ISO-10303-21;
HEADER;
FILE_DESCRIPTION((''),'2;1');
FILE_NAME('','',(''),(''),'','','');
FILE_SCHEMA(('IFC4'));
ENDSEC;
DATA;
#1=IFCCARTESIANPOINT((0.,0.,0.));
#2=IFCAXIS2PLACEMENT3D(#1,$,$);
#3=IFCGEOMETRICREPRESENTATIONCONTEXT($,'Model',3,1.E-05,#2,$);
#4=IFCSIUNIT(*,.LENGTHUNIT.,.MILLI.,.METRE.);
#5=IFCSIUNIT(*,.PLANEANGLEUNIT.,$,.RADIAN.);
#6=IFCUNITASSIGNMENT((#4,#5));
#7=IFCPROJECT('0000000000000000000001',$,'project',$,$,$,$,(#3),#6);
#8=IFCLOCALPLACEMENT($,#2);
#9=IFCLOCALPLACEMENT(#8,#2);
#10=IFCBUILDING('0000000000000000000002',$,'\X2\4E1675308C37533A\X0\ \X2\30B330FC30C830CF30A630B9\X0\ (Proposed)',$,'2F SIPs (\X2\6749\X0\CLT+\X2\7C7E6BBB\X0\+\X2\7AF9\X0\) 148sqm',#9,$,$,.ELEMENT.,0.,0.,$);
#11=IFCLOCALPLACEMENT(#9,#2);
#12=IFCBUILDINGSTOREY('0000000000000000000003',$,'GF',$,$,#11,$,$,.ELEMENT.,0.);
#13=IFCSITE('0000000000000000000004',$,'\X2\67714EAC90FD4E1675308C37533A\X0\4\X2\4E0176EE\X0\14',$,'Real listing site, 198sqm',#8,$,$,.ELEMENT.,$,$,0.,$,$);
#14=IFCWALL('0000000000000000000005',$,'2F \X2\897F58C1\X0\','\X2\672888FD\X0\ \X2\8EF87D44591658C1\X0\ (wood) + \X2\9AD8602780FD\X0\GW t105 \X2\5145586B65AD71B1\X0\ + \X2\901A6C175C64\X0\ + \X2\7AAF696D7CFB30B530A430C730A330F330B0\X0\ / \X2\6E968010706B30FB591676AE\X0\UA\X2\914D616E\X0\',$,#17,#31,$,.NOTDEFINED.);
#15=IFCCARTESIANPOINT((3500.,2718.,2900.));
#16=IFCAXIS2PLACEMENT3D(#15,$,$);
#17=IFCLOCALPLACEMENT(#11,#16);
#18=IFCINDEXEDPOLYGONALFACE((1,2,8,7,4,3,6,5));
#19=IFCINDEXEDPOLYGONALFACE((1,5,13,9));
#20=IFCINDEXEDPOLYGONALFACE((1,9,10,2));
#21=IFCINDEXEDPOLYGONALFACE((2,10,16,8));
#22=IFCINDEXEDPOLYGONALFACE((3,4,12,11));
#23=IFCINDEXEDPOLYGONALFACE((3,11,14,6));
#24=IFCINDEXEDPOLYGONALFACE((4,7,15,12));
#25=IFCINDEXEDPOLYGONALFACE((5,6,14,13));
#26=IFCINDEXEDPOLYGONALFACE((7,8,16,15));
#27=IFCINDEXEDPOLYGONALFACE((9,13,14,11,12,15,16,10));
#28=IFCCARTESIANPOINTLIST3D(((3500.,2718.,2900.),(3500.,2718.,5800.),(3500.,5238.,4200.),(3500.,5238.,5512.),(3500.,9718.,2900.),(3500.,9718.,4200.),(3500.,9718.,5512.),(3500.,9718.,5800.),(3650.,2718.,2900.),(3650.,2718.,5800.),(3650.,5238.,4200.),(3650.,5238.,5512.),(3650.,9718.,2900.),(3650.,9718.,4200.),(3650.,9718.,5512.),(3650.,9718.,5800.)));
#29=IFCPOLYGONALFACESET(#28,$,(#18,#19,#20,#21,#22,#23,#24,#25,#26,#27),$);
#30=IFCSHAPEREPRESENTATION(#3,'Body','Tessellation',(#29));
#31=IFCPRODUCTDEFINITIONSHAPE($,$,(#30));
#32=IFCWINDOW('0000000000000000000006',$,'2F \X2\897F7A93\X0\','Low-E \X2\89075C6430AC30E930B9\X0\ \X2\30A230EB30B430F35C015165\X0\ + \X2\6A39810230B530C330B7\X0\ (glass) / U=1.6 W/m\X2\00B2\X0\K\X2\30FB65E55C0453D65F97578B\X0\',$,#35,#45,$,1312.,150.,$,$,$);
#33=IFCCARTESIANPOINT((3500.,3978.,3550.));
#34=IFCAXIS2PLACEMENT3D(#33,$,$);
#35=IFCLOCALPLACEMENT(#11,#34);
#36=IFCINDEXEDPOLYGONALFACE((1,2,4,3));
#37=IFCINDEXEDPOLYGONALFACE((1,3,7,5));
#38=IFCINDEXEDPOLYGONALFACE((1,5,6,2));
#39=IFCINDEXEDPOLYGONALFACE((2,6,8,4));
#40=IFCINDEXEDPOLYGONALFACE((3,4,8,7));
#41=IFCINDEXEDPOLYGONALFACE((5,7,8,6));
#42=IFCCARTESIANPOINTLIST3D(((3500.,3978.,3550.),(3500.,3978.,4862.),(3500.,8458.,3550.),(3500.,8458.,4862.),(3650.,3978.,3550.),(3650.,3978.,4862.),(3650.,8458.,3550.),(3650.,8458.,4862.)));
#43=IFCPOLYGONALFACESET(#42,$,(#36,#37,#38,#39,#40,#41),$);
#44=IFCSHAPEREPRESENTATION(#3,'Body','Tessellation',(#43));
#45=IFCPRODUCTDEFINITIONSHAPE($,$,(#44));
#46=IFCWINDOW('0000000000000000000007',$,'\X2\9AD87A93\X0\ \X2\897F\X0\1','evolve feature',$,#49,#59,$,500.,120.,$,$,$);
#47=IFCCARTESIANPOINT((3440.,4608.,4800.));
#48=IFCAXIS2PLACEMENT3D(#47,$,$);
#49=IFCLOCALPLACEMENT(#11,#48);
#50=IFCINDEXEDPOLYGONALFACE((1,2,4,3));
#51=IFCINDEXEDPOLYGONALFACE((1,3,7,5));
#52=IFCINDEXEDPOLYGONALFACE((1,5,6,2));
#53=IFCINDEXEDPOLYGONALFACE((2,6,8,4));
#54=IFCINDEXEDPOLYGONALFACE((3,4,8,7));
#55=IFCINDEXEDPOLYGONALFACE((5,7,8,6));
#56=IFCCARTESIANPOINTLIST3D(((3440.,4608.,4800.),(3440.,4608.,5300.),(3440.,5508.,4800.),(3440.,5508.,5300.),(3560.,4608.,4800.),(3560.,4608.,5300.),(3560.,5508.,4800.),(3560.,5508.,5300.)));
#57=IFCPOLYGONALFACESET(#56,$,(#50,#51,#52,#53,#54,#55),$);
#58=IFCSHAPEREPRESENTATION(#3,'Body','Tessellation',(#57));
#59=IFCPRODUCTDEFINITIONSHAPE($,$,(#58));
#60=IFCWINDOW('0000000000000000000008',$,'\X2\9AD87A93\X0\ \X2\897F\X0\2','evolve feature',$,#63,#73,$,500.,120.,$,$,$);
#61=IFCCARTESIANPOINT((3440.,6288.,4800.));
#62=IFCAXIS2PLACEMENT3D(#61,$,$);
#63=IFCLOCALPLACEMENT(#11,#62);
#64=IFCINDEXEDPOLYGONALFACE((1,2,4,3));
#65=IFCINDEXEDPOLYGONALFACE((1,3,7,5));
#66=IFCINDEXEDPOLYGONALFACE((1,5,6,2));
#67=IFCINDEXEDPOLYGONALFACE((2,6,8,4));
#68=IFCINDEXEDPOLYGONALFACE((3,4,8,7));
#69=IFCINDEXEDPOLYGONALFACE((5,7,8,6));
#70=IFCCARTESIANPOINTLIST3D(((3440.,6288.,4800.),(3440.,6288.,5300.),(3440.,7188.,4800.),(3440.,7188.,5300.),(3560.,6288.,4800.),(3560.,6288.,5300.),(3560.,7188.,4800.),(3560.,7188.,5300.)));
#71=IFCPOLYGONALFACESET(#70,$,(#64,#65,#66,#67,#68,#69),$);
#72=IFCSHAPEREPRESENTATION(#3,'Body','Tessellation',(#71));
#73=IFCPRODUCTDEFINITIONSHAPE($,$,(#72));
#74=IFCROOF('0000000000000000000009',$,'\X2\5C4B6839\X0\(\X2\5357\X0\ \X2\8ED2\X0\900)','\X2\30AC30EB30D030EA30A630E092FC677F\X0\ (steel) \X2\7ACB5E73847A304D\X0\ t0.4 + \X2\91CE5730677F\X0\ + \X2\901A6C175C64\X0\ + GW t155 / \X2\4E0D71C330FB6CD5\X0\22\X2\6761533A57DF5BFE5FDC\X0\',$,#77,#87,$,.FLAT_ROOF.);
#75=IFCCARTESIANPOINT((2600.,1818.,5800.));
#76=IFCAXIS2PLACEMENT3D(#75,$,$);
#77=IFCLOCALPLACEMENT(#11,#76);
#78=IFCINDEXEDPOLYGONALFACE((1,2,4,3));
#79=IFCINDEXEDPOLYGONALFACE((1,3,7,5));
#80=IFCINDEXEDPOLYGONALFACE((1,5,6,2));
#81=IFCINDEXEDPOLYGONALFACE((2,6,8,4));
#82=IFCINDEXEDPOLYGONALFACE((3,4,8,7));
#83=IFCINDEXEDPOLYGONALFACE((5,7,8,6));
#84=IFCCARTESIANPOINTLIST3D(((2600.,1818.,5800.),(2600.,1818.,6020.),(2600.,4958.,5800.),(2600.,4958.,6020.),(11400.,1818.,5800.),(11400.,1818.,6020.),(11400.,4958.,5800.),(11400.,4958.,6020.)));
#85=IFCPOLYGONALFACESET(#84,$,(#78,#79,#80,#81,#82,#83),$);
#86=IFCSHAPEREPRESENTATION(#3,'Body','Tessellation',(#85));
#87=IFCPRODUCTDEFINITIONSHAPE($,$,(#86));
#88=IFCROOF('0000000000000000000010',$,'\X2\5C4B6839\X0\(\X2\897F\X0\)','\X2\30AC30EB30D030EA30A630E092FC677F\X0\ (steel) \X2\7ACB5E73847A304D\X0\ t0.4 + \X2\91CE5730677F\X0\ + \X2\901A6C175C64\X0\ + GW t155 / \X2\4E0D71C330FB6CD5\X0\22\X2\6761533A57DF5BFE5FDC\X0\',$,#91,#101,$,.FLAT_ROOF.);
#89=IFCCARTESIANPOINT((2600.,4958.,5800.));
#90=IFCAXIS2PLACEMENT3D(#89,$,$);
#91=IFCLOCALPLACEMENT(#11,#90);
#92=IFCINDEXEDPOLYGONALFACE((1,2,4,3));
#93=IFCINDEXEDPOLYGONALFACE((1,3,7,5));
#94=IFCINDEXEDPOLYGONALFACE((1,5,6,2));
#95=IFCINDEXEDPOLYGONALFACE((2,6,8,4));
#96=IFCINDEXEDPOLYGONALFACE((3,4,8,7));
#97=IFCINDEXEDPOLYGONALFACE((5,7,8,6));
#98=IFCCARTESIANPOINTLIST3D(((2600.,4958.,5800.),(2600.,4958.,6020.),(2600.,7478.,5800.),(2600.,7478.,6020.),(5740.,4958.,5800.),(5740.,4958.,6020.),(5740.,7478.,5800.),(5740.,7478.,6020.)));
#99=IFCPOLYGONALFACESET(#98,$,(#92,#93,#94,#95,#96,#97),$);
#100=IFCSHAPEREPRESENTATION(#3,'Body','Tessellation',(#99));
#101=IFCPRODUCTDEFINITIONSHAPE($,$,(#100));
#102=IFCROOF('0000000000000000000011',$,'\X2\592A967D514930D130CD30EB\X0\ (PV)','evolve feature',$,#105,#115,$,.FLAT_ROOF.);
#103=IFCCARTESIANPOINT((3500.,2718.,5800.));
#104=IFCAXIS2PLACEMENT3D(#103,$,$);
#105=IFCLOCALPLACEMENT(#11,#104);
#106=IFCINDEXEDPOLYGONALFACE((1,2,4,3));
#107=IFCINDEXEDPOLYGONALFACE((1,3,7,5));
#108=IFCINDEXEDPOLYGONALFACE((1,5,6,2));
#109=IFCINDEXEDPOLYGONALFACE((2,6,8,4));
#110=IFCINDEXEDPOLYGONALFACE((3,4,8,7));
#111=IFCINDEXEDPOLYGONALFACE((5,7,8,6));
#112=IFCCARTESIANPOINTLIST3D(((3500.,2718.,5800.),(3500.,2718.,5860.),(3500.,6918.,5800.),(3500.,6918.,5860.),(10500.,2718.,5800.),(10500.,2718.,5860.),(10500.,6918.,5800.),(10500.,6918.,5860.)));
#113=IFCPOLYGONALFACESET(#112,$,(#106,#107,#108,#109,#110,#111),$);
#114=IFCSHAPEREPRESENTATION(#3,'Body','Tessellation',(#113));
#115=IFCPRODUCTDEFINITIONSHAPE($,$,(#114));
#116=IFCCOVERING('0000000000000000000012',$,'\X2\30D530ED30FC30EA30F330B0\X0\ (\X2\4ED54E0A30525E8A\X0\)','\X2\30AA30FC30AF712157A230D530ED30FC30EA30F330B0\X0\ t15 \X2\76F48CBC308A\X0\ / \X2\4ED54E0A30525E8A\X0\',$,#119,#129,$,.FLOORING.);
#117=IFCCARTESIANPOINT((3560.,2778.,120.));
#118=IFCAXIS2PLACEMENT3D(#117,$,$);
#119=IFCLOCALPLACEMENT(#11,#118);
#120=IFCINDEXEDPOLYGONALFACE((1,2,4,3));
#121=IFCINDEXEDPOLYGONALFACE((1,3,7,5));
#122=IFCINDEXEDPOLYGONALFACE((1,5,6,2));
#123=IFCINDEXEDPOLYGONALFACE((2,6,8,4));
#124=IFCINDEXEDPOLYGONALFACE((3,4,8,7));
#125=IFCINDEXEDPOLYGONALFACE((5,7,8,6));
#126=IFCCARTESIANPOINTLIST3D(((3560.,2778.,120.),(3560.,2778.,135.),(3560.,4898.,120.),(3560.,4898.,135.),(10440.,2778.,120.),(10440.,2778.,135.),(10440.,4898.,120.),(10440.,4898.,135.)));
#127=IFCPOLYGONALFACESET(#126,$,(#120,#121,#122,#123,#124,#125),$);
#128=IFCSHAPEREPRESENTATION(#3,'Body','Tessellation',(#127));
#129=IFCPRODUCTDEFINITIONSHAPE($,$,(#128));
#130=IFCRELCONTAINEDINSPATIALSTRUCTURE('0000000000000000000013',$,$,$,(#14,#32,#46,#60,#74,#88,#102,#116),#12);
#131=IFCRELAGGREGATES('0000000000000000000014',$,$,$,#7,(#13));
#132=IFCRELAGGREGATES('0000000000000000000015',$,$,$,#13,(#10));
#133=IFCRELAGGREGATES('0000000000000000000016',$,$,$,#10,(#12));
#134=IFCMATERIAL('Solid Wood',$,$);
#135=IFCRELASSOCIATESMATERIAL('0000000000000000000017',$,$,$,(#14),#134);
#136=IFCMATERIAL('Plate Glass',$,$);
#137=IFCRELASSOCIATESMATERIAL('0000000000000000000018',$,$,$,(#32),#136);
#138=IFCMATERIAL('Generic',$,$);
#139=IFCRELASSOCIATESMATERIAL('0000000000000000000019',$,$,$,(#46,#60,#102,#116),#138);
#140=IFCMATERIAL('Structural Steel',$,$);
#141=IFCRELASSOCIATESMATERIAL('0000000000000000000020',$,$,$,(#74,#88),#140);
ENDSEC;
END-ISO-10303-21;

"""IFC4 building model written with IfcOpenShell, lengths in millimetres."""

from ifc_helpers import new_model, si_unit, frame, frame_2d, origin, place, context, project, spatial, rectangle, extrude, material, element, fill, save


model = new_model("IFC4")

# Units and contexts
model_context = context("Model", 3, precision=1e-05, world=origin())
ifc_project = project(units=[si_unit("LENGTHUNIT", "METRE", prefix="MILLI"), si_unit("PLANEANGLEUNIT", "RADIAN")], contexts=[model_context])

# Site, building, storey
site_placement = place(None, origin())
site = spatial("IfcSite", under=ifc_project, at=site_placement, Name="東京都世田谷区4丁目14", ObjectType="Real listing site, 198sqm", CompositionType="ELEMENT", RefElevation=0.0)
building_placement = place(site_placement, origin())
building = spatial("IfcBuilding", under=site, at=building_placement, Name="世田谷区 コートハウス (Proposed)", ObjectType="2F SIPs (杉CLT+籾殻+竹) 148sqm", CompositionType="ELEMENT", ElevationOfRefHeight=0.0, ElevationOfTerrain=0.0)
storey_placement = place(building_placement, origin())
storey = spatial("IfcBuildingStorey", under=building, at=storey_placement, Name="GF", CompositionType="ELEMENT", Elevation=0.0)

# Shared definitions
ifc_material_1 = material(Name="Solid Wood")
ifc_material_2 = material(Name="Generic")

# Shared definitions
ifc_material_3 = material(Name="Plate Glass")

# Wall, openings, windows
wall_1_placement = place(storey_placement, frame((3500.0, 2718.0, 2900.0)))
wall_1 = element("IfcWall", 1, at=wall_1_placement, inside=storey, material=ifc_material_1, Name="2F 西壁", Description="木製 軸組外壁 (wood) + 高性能GW t105 充填断熱 + 通気層 + 窯業系サイディング / 準耐火・外皮UA配慮", PredefinedType="NOTDEFINED", context=model_context, shape_type="SweptSolid", body=[
    extrude(rectangle(XDim=150.0, YDim=7000.0, at=frame_2d((75.0, 3500.0))), frame((3500.0, 2718.0, 2900.0)), (0.0, 0.0, 1.0), 2900.0),
])
opening_1_placement = place(storey_placement, frame((3500.0, 3978.0, 3550.0)))
opening_1 = element("IfcOpeningElement", 2, at=opening_1_placement, cuts=wall_1, PredefinedType="NOTDEFINED", context=model_context, shape_type="SweptSolid", body=[
    extrude(rectangle(XDim=150.0, YDim=4480.0, at=frame_2d((75.0, 2240.0))), frame((3500.0, 3978.0, 3550.0)), (0.0, 0.0, 1.0), 1312.0),
])
opening_2_placement = place(storey_placement, frame((3440.0, 4608.0, 4800.0)))
opening_2 = element("IfcOpeningElement", 3, at=opening_2_placement, cuts=wall_1, PredefinedType="NOTDEFINED", context=model_context, shape_type="SweptSolid", body=[
    extrude(rectangle(XDim=120.0, YDim=900.0, at=frame_2d((60.0, 450.0))), frame((3440.0, 4608.0, 4800.0)), (0.0, 0.0, 1.0), 500.0),
])
opening_3_placement = place(storey_placement, frame((3440.0, 6288.0, 4800.0)))
opening_3 = element("IfcOpeningElement", 4, at=opening_3_placement, cuts=wall_1, PredefinedType="NOTDEFINED", context=model_context, shape_type="SweptSolid", body=[
    extrude(rectangle(XDim=120.0, YDim=900.0, at=frame_2d((60.0, 450.0))), frame((3440.0, 6288.0, 4800.0)), (0.0, 0.0, 1.0), 500.0),
])
window_1_placement = place(storey_placement, frame((3500.0, 3978.0, 3550.0)))
window_1 = element("IfcWindow", 5, at=window_1_placement, inside=storey, material=ifc_material_3, Name="2F 西窓", Description="Low-E 複層ガラス アルゴン封入 + 樹脂サッシ (glass) / U=1.6 W/m²K・日射取得型", OverallHeight=1312.0, OverallWidth=150.0, context=model_context, shape_type="SweptSolid", body=[
    extrude(rectangle(XDim=150.0, YDim=4480.0, at=frame_2d((75.0, 2240.0))), frame((3500.0, 3978.0, 3550.0)), (0.0, 0.0, 1.0), 1312.0),
])
fill(opening_1, window_1)
window_2_placement = place(storey_placement, frame((3440.0, 4608.0, 4800.0)))
window_2 = element("IfcWindow", 6, at=window_2_placement, inside=storey, material=ifc_material_2, Name="高窓 西1", Description="evolve feature", OverallHeight=500.0, OverallWidth=120.0, context=model_context, shape_type="SweptSolid", body=[
    extrude(rectangle(XDim=120.0, YDim=900.0, at=frame_2d((60.0, 450.0))), frame((3440.0, 4608.0, 4800.0)), (0.0, 0.0, 1.0), 500.0),
])
fill(opening_2, window_2)
window_3_placement = place(storey_placement, frame((3440.0, 6288.0, 4800.0)))
window_3 = element("IfcWindow", 7, at=window_3_placement, inside=storey, material=ifc_material_2, Name="高窓 西2", Description="evolve feature", OverallHeight=500.0, OverallWidth=120.0, context=model_context, shape_type="SweptSolid", body=[
    extrude(rectangle(XDim=120.0, YDim=900.0, at=frame_2d((60.0, 450.0))), frame((3440.0, 6288.0, 4800.0)), (0.0, 0.0, 1.0), 500.0),
])
fill(opening_3, window_3)

# Roofs
ifc_material_4 = material(Name="Structural Steel")
roof_1_placement = place(storey_placement, frame((2600.0, 1818.0, 5800.0)))
element("IfcRoof", 8, at=roof_1_placement, inside=storey, material=ifc_material_4, Name="屋根(南 軒900)", Description="ガルバリウム鋼板 (steel) 立平葺き t0.4 + 野地板 + 通気層 + GW t155 / 不燃・法22条区域対応", PredefinedType="FLAT_ROOF", context=model_context, shape_type="SweptSolid", body=[
    extrude(rectangle(XDim=8800.0, YDim=3140.0, at=frame_2d((4400.0, 1570.0))), frame((2600.0, 1818.0, 5800.0)), (0.0, 0.0, 1.0), 220.0),
])
roof_2_placement = place(storey_placement, frame((2600.0, 4958.0, 5800.0)))
element("IfcRoof", 9, at=roof_2_placement, inside=storey, material=ifc_material_4, Name="屋根(西)", Description="ガルバリウム鋼板 (steel) 立平葺き t0.4 + 野地板 + 通気層 + GW t155 / 不燃・法22条区域対応", PredefinedType="FLAT_ROOF", context=model_context, shape_type="SweptSolid", body=[
    extrude(rectangle(XDim=3140.0, YDim=2520.0, at=frame_2d((1570.0, 1260.0))), frame((2600.0, 4958.0, 5800.0)), (0.0, 0.0, 1.0), 220.0),
])
roof_3_placement = place(storey_placement, frame((3500.0, 2718.0, 5800.0)))
element("IfcRoof", 10, at=roof_3_placement, inside=storey, material=ifc_material_2, Name="太陽光パネル (PV)", Description="evolve feature", PredefinedType="FLAT_ROOF", context=model_context, shape_type="SweptSolid", body=[
    extrude(rectangle(XDim=7000.0, YDim=4200.0, at=frame_2d((3500.0, 2100.0))), frame((3500.0, 2718.0, 5800.0)), (0.0, 0.0, 1.0), 60.0),
])

# Covering
covering_placement = place(storey_placement, frame((3560.0, 2778.0, 120.0)))
element("IfcCovering", 11, at=covering_placement, inside=storey, material=ifc_material_2, Name="フローリング (仕上げ床)", Description="オーク無垢フローリング t15 直貼り / 仕上げ床", PredefinedType="FLOORING", context=model_context, shape_type="SweptSolid", body=[
    extrude(rectangle(XDim=6880.0, YDim=2120.0, at=frame_2d((3440.0, 1060.0))), frame((3560.0, 2778.0, 120.0)), (0.0, 0.0, 1.0), 15.0),
])

save(model, "model.ifc")
